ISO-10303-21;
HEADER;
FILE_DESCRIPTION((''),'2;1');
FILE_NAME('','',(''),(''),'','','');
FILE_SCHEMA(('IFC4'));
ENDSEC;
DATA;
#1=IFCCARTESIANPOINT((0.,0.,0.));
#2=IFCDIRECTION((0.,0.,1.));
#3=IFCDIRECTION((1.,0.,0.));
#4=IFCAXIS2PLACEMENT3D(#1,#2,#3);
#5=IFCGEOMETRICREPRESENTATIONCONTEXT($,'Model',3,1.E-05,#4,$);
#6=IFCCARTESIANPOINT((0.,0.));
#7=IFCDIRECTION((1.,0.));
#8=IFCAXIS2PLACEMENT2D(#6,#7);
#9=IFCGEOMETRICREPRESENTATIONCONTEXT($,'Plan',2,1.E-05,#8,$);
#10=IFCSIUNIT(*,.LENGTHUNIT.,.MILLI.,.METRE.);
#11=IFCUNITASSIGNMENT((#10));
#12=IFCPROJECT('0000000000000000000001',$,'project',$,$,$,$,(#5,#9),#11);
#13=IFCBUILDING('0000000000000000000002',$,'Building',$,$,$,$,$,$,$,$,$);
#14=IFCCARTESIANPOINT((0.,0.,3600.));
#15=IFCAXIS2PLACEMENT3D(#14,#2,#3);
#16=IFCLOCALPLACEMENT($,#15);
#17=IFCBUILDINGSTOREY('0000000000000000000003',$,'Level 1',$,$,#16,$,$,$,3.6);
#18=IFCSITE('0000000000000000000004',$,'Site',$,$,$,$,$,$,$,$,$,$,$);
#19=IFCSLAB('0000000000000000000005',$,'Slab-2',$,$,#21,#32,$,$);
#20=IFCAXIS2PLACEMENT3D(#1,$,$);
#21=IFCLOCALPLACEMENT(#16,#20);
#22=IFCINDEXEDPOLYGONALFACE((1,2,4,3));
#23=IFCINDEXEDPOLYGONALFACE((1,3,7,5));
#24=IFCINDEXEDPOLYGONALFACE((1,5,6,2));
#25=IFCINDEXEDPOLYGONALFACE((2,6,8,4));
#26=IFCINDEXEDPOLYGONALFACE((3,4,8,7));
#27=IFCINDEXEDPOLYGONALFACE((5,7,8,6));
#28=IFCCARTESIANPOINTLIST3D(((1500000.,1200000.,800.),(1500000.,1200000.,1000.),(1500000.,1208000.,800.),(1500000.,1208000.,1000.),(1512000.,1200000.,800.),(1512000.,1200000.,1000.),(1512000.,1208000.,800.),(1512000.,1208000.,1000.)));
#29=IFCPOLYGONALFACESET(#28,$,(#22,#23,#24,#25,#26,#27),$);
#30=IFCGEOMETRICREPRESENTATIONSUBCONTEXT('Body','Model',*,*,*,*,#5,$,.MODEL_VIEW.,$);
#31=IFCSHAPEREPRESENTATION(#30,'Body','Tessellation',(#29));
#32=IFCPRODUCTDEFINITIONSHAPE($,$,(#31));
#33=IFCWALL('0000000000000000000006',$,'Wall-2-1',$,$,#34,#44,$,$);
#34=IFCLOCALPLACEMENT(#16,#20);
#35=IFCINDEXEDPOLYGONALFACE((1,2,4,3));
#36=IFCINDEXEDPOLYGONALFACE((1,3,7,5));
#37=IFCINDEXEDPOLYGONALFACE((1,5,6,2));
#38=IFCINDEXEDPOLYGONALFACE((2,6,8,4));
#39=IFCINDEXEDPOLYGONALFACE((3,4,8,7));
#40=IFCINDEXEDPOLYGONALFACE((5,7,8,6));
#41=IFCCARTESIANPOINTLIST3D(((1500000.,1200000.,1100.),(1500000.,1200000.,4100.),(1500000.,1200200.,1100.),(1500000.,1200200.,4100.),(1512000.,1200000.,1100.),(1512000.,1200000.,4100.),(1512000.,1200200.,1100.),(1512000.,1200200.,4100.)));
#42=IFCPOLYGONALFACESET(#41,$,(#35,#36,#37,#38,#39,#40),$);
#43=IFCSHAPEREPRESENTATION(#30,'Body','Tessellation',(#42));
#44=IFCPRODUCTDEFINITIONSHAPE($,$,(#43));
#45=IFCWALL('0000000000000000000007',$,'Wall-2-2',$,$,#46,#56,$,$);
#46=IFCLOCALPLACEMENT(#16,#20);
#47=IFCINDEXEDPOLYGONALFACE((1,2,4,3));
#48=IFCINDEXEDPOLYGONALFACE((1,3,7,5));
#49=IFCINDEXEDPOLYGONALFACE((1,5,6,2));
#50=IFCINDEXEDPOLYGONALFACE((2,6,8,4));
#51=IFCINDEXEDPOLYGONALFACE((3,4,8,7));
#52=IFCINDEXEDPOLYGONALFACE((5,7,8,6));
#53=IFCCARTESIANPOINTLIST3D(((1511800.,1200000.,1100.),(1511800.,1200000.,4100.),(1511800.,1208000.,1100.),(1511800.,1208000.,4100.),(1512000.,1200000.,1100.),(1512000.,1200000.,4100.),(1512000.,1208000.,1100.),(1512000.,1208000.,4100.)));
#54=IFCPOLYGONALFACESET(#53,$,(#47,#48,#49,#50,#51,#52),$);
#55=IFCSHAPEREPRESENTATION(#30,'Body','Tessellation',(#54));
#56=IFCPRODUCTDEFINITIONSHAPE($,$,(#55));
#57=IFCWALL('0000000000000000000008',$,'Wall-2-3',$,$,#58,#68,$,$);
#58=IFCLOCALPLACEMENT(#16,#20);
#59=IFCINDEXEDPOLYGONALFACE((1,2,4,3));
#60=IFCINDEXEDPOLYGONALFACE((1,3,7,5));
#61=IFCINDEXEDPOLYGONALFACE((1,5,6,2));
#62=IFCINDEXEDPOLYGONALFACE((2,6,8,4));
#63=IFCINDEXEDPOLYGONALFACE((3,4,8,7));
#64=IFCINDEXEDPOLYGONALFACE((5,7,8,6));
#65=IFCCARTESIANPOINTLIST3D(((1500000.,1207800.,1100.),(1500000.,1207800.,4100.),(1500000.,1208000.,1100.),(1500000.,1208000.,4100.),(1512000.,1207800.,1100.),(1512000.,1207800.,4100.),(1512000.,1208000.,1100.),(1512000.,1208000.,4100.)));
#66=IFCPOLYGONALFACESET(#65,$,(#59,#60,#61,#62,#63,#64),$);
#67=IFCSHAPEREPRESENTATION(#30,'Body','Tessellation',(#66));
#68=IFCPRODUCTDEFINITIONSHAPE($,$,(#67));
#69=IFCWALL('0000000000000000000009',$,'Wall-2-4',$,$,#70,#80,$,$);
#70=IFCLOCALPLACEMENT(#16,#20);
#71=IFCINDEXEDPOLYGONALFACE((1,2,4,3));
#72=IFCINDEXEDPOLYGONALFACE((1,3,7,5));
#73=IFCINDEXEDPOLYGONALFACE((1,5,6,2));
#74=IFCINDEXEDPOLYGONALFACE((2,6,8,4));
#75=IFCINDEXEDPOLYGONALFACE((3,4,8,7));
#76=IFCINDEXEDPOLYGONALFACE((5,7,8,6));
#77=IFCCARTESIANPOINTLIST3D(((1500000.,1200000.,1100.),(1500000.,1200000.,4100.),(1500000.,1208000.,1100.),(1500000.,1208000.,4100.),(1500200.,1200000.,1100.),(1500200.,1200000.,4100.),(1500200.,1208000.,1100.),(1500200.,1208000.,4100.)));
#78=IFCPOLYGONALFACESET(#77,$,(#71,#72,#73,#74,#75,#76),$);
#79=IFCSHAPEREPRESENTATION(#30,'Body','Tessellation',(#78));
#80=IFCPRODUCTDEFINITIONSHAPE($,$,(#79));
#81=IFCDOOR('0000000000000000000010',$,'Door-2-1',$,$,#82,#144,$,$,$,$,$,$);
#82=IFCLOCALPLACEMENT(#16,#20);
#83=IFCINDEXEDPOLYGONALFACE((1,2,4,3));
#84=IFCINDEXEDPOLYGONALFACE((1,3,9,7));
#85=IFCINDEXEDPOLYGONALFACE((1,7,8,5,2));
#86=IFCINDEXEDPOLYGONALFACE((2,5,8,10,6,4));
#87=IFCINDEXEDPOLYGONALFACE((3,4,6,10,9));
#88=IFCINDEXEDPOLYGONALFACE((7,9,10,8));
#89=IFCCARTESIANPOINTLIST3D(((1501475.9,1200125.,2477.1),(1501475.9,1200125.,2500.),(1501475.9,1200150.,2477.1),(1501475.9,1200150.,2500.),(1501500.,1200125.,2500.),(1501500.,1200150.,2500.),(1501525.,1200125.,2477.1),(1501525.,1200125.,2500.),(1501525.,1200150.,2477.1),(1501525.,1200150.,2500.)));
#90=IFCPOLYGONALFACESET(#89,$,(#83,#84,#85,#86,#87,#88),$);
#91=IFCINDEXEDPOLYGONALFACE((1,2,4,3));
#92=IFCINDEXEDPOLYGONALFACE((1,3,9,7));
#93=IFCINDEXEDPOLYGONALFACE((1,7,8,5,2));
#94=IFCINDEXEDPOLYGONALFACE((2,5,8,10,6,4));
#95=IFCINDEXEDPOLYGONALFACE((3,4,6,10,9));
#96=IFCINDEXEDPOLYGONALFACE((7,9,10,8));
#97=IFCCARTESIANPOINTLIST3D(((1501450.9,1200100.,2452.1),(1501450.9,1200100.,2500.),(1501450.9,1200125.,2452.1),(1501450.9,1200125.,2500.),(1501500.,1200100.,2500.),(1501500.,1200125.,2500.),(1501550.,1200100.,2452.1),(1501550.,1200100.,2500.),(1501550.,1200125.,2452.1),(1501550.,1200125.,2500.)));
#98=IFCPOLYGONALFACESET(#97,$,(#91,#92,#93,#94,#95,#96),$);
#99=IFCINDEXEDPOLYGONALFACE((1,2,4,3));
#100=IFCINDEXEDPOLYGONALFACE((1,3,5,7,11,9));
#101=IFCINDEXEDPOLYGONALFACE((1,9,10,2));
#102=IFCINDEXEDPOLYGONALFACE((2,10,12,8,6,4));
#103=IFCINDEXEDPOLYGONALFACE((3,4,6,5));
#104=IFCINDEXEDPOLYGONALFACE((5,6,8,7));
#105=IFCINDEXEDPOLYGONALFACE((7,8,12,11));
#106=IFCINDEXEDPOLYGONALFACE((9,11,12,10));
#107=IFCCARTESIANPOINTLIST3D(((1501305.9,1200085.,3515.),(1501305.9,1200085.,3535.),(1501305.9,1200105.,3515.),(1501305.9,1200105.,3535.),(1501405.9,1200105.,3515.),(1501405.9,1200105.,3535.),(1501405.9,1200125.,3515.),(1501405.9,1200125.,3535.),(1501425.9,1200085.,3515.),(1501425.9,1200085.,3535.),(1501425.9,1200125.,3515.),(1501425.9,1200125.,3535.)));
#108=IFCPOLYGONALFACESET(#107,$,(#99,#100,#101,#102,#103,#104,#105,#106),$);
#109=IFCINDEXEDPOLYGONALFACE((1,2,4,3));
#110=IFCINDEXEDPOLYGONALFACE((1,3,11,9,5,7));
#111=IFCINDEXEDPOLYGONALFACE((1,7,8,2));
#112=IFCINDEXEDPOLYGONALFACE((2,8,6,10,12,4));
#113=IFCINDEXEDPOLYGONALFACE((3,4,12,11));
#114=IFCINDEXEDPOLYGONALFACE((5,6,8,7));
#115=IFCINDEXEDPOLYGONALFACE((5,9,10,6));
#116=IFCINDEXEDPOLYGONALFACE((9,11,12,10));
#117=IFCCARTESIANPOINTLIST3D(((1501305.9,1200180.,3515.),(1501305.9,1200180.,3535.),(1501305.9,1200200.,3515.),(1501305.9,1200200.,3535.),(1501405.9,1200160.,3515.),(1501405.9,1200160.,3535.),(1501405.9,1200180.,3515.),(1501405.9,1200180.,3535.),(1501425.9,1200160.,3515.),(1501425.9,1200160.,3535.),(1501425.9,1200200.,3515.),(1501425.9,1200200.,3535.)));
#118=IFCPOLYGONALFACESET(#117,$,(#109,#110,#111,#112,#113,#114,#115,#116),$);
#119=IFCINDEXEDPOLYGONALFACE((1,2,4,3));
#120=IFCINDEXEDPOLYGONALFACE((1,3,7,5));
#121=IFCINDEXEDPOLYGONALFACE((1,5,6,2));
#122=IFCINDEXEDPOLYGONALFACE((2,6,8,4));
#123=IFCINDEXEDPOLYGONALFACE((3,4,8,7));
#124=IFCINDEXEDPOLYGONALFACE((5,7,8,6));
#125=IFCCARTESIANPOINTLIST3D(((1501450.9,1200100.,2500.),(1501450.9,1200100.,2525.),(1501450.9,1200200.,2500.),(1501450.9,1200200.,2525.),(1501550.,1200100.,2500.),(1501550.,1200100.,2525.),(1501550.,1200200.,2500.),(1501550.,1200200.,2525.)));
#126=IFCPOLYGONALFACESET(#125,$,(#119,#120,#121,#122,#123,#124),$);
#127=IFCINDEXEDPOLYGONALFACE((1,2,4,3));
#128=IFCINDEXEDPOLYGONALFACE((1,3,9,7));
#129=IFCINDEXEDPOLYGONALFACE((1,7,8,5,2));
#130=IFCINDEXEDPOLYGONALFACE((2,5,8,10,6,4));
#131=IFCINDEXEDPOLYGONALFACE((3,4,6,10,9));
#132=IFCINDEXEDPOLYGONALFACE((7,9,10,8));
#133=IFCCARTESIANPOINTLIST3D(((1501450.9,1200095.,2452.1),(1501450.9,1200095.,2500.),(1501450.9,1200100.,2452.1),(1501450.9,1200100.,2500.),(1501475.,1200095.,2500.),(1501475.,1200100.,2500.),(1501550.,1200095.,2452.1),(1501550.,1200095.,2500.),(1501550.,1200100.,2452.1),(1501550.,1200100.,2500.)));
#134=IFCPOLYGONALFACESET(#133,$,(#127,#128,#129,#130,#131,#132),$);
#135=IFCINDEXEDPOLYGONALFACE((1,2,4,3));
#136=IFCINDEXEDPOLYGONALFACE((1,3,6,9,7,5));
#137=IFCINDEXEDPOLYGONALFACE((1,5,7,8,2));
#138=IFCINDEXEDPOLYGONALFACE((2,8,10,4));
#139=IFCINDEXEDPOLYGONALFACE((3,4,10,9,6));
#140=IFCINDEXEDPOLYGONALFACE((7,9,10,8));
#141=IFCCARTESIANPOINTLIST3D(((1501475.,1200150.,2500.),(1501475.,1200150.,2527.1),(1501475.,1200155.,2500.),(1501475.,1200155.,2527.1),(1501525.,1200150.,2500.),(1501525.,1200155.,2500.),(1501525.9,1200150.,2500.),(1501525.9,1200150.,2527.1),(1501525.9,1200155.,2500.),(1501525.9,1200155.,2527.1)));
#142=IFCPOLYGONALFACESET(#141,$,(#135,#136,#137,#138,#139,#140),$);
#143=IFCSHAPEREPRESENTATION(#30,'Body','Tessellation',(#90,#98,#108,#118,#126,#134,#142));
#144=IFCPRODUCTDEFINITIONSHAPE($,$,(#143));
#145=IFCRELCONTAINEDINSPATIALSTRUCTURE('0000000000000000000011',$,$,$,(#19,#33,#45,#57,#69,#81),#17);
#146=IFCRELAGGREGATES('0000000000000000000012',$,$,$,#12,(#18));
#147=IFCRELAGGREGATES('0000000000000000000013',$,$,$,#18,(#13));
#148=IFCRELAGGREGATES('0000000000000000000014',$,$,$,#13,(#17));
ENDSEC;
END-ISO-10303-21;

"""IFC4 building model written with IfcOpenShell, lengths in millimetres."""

from ifc_helpers import new_model, si_unit, frame, origin_with_axes, origin_2d_with_axis, place, context, subcontext, project, spatial, line, indexed_curve, outline, extrude, element, save


model = new_model("IFC4")

# Units and contexts
model_context = context("Model", 3, precision=1e-05, world=origin_with_axes())
plan_context = context("Plan", 2, precision=1e-05, world=origin_2d_with_axis())
body_context = subcontext(model_context, "Body", "Model", "MODEL_VIEW")
ifc_project = project(units=[si_unit("LENGTHUNIT", "METRE", prefix="MILLI")], contexts=[model_context, plan_context])

# Site, building, storey
site = spatial("IfcSite", under=ifc_project, Name="Site")
building = spatial("IfcBuilding", under=site, Name="Building")
storey_placement = place(None, frame((0.0, 0.0, 3600.0), z_axis=(0.0, 0.0, 1.0), x_axis=(1.0, 0.0, 0.0)))
storey = spatial("IfcBuildingStorey", under=building, at=storey_placement, Name="Level 1", Elevation=3.6)

# Slab
slab_placement = place(storey_placement, frame((1500000.0, 1200000.0, 800.0), z_axis=(0.0, 0.0, 1.0), x_axis=(1.0, 0.0, 0.0)))
element("IfcSlab", 1, at=slab_placement, inside=storey, Name="Slab-2", context=body_context, shape_type="SweptSolid", body=[
    extrude(outline(indexed_curve([(0.0, 0.0), (12000.0, 0.0), (12000.0, 8000.0), (0.0, 8000.0), (0.0, 0.0)])), None, (0.0, 0.0, 1.0), 200.0),
])

# Walls
wall_1_placement = place(storey_placement, frame((1500000.0, 1200000.0, 1100.0), z_axis=(0.0, 0.0, 1.0), x_axis=(1.0, 0.0, 0.0)))
element("IfcWall", 2, at=wall_1_placement, inside=storey, Name="Wall-2-1", context=body_context, shape_type="SweptSolid", body=[
    extrude(outline(indexed_curve([(0.0, 0.0), (0.0, 200.0), (12000.0, 200.0), (12000.0, 0.0), (0.0, 0.0)], self_intersect=False)), origin_with_axes(), (0.0, 0.0, 1.0), 3000.0),
])
wall_2_placement = place(storey_placement, frame((1512000.0, 1200000.0, 1100.0), z_axis=(0.0, 0.0, 1.0), x_axis=(0.0, 1.0, 0.0)))
element("IfcWall", 3, at=wall_2_placement, inside=storey, Name="Wall-2-2", context=body_context, shape_type="SweptSolid", body=[
    extrude(outline(indexed_curve([(0.0, 0.0), (0.0, 200.0), (8000.0, 200.0), (8000.0, 0.0), (0.0, 0.0)], self_intersect=False)), origin_with_axes(), (0.0, 0.0, 1.0), 3000.0),
])
wall_3_placement = place(storey_placement, frame((1512000.0, 1208000.0, 1100.0), z_axis=(0.0, 0.0, 1.0), x_axis=(-1.0, 0.0, 0.0)))
element("IfcWall", 4, at=wall_3_placement, inside=storey, Name="Wall-2-3", context=body_context, shape_type="SweptSolid", body=[
    extrude(outline(indexed_curve([(0.0, 0.0), (0.0, 200.0), (12000.0, 200.0), (12000.0, 0.0), (0.0, 0.0)], self_intersect=False)), origin_with_axes(), (0.0, 0.0, 1.0), 3000.0),
])
wall_4_placement = place(storey_placement, frame((1500000.0, 1208000.0, 1100.0), z_axis=(0.0, 0.0, 1.0), x_axis=(0.0, -1.0, 0.0)))
element("IfcWall", 5, at=wall_4_placement, inside=storey, Name="Wall-2-4", context=body_context, shape_type="SweptSolid", body=[
    extrude(outline(indexed_curve([(0.0, 0.0), (0.0, 200.0), (8000.0, 200.0), (8000.0, 0.0), (0.0, 0.0)], self_intersect=False)), origin_with_axes(), (0.0, 0.0, 1.0), 3000.0),
])

# Door
door_1_placement = place(storey_placement, frame((1501500.0, 1200100.0, 2500.0), z_axis=(0.0, 0.0, 1.0), x_axis=(1.0, 0.0, 0.0)))
element("IfcDoor", 6, at=door_1_placement, inside=storey, Name="Door-2-1", context=body_context, shape_type="SweptSolid", body=[
    extrude(outline(indexed_curve([(0.0, 0.0), (0.0, 2.1), (0.9, 2.1), (0.9, 0.0), (-24.1, 0.0), (-24.1, -22.9), (25.0, -22.9), (25.0, 0.0)], segments=[line(1, 2, 3, 4, 5, 6, 7, 8, 1)])), frame((0.0, 25.0, 0.0), z_axis=(0.0, -1.0, 0.0), x_axis=(1.0, 0.0, 0.0)), (0.0, 0.0, -1.0), 25.0),
    extrude(outline(indexed_curve([(0.0, 0.0), (0.0, 2.1), (0.9, 2.1), (0.9, 0.0), (-49.1, 0.0), (-49.1, -47.9), (50.0, -47.9), (50.0, 0.0)], segments=[line(1, 2, 3, 4, 5, 6, 7, 8, 1)])), frame((0.0, 0.0, 0.0), z_axis=(0.0, -1.0, 0.0), x_axis=(1.0, 0.0, 0.0)), (0.0, 0.0, -1.0), 25.0),
    extrude(outline(indexed_curve([(0.0, 0.0), (-49.1, 0.0), (-49.1, 35.0), (0.0, 35.0)], segments=[line(1, 2, 3, 4, 1)])), frame((25.0, 25.0, 25.0), z_axis=(0.0, 0.0, 1.0), x_axis=(1.0, 0.0, 0.0)), (0.0, 0.0, 1.0), -47.9),
    extrude(outline(indexed_curve([(0.0, 0.0), (0.0, -40.0), (-120.0, -40.0), (-120.0, -20.0), (-20.0, -20.0), (-20.0, 0.0)], segments=[line(1, 2, 3, 4, 5, 6, 1)])), frame((-74.1, 25.0, 1015.0), z_axis=(0.0, 0.0, 1.0), x_axis=(1.0, 0.0, 0.0)), (0.0, 0.0, 1.0), 20.0),
    extrude(outline(indexed_curve([(0.0, 0.0), (0.0, 40.0), (-120.0, 40.0), (-120.0, 20.0), (-20.0, 20.0), (-20.0, 0.0)], segments=[line(1, 2, 3, 4, 5, 6, 1)])), frame((-74.1, 60.0, 1015.0), z_axis=(0.0, 0.0, 1.0), x_axis=(1.0, 0.0, 0.0)), (0.0, 0.0, 1.0), 20.0),
    extrude(outline(indexed_curve([(0.0, 0.0), (-99.1, 0.0), (-99.1, 100.0), (0.0, 100.0)], segments=[line(1, 2, 3, 4, 1)])), frame((50.0, 0.0, 0.0), z_axis=(0.0, 0.0, 1.0), x_axis=(1.0, 0.0, 0.0)), (0.0, 0.0, 1.0), 25.0),
    extrude(outline(indexed_curve([(0.0, 0.0), (0.0, 27.1), (50.9, 27.1), (50.9, 0.0), (-24.1, 0.0), (-24.1, -47.9), (75.0, -47.9), (75.0, 0.0)], segments=[line(1, 2, 3, 4, 5, 6, 7, 8, 1)])), frame((-25.0, -5.0, 0.0), z_axis=(0.0, -1.0, 0.0), x_axis=(1.0, 0.0, 0.0)), (0.0, 0.0, -1.0), 5.0),
    extrude(outline(indexed_curve([(0.0, 0.0), (0.0, 27.1), (50.9, 27.1), (50.9, 0.0), (0.9, 0.0), (0.9, -22.9), (50.0, -22.9), (50.0, 0.0)], segments=[line(1, 2, 3, 4, 5, 6, 7, 8, 1)])), frame((-25.0, 50.0, 0.0), z_axis=(0.0, -1.0, 0.0), x_axis=(1.0, 0.0, 0.0)), (0.0, 0.0, -1.0), 5.0),
])

save(model, "model.ifc")
